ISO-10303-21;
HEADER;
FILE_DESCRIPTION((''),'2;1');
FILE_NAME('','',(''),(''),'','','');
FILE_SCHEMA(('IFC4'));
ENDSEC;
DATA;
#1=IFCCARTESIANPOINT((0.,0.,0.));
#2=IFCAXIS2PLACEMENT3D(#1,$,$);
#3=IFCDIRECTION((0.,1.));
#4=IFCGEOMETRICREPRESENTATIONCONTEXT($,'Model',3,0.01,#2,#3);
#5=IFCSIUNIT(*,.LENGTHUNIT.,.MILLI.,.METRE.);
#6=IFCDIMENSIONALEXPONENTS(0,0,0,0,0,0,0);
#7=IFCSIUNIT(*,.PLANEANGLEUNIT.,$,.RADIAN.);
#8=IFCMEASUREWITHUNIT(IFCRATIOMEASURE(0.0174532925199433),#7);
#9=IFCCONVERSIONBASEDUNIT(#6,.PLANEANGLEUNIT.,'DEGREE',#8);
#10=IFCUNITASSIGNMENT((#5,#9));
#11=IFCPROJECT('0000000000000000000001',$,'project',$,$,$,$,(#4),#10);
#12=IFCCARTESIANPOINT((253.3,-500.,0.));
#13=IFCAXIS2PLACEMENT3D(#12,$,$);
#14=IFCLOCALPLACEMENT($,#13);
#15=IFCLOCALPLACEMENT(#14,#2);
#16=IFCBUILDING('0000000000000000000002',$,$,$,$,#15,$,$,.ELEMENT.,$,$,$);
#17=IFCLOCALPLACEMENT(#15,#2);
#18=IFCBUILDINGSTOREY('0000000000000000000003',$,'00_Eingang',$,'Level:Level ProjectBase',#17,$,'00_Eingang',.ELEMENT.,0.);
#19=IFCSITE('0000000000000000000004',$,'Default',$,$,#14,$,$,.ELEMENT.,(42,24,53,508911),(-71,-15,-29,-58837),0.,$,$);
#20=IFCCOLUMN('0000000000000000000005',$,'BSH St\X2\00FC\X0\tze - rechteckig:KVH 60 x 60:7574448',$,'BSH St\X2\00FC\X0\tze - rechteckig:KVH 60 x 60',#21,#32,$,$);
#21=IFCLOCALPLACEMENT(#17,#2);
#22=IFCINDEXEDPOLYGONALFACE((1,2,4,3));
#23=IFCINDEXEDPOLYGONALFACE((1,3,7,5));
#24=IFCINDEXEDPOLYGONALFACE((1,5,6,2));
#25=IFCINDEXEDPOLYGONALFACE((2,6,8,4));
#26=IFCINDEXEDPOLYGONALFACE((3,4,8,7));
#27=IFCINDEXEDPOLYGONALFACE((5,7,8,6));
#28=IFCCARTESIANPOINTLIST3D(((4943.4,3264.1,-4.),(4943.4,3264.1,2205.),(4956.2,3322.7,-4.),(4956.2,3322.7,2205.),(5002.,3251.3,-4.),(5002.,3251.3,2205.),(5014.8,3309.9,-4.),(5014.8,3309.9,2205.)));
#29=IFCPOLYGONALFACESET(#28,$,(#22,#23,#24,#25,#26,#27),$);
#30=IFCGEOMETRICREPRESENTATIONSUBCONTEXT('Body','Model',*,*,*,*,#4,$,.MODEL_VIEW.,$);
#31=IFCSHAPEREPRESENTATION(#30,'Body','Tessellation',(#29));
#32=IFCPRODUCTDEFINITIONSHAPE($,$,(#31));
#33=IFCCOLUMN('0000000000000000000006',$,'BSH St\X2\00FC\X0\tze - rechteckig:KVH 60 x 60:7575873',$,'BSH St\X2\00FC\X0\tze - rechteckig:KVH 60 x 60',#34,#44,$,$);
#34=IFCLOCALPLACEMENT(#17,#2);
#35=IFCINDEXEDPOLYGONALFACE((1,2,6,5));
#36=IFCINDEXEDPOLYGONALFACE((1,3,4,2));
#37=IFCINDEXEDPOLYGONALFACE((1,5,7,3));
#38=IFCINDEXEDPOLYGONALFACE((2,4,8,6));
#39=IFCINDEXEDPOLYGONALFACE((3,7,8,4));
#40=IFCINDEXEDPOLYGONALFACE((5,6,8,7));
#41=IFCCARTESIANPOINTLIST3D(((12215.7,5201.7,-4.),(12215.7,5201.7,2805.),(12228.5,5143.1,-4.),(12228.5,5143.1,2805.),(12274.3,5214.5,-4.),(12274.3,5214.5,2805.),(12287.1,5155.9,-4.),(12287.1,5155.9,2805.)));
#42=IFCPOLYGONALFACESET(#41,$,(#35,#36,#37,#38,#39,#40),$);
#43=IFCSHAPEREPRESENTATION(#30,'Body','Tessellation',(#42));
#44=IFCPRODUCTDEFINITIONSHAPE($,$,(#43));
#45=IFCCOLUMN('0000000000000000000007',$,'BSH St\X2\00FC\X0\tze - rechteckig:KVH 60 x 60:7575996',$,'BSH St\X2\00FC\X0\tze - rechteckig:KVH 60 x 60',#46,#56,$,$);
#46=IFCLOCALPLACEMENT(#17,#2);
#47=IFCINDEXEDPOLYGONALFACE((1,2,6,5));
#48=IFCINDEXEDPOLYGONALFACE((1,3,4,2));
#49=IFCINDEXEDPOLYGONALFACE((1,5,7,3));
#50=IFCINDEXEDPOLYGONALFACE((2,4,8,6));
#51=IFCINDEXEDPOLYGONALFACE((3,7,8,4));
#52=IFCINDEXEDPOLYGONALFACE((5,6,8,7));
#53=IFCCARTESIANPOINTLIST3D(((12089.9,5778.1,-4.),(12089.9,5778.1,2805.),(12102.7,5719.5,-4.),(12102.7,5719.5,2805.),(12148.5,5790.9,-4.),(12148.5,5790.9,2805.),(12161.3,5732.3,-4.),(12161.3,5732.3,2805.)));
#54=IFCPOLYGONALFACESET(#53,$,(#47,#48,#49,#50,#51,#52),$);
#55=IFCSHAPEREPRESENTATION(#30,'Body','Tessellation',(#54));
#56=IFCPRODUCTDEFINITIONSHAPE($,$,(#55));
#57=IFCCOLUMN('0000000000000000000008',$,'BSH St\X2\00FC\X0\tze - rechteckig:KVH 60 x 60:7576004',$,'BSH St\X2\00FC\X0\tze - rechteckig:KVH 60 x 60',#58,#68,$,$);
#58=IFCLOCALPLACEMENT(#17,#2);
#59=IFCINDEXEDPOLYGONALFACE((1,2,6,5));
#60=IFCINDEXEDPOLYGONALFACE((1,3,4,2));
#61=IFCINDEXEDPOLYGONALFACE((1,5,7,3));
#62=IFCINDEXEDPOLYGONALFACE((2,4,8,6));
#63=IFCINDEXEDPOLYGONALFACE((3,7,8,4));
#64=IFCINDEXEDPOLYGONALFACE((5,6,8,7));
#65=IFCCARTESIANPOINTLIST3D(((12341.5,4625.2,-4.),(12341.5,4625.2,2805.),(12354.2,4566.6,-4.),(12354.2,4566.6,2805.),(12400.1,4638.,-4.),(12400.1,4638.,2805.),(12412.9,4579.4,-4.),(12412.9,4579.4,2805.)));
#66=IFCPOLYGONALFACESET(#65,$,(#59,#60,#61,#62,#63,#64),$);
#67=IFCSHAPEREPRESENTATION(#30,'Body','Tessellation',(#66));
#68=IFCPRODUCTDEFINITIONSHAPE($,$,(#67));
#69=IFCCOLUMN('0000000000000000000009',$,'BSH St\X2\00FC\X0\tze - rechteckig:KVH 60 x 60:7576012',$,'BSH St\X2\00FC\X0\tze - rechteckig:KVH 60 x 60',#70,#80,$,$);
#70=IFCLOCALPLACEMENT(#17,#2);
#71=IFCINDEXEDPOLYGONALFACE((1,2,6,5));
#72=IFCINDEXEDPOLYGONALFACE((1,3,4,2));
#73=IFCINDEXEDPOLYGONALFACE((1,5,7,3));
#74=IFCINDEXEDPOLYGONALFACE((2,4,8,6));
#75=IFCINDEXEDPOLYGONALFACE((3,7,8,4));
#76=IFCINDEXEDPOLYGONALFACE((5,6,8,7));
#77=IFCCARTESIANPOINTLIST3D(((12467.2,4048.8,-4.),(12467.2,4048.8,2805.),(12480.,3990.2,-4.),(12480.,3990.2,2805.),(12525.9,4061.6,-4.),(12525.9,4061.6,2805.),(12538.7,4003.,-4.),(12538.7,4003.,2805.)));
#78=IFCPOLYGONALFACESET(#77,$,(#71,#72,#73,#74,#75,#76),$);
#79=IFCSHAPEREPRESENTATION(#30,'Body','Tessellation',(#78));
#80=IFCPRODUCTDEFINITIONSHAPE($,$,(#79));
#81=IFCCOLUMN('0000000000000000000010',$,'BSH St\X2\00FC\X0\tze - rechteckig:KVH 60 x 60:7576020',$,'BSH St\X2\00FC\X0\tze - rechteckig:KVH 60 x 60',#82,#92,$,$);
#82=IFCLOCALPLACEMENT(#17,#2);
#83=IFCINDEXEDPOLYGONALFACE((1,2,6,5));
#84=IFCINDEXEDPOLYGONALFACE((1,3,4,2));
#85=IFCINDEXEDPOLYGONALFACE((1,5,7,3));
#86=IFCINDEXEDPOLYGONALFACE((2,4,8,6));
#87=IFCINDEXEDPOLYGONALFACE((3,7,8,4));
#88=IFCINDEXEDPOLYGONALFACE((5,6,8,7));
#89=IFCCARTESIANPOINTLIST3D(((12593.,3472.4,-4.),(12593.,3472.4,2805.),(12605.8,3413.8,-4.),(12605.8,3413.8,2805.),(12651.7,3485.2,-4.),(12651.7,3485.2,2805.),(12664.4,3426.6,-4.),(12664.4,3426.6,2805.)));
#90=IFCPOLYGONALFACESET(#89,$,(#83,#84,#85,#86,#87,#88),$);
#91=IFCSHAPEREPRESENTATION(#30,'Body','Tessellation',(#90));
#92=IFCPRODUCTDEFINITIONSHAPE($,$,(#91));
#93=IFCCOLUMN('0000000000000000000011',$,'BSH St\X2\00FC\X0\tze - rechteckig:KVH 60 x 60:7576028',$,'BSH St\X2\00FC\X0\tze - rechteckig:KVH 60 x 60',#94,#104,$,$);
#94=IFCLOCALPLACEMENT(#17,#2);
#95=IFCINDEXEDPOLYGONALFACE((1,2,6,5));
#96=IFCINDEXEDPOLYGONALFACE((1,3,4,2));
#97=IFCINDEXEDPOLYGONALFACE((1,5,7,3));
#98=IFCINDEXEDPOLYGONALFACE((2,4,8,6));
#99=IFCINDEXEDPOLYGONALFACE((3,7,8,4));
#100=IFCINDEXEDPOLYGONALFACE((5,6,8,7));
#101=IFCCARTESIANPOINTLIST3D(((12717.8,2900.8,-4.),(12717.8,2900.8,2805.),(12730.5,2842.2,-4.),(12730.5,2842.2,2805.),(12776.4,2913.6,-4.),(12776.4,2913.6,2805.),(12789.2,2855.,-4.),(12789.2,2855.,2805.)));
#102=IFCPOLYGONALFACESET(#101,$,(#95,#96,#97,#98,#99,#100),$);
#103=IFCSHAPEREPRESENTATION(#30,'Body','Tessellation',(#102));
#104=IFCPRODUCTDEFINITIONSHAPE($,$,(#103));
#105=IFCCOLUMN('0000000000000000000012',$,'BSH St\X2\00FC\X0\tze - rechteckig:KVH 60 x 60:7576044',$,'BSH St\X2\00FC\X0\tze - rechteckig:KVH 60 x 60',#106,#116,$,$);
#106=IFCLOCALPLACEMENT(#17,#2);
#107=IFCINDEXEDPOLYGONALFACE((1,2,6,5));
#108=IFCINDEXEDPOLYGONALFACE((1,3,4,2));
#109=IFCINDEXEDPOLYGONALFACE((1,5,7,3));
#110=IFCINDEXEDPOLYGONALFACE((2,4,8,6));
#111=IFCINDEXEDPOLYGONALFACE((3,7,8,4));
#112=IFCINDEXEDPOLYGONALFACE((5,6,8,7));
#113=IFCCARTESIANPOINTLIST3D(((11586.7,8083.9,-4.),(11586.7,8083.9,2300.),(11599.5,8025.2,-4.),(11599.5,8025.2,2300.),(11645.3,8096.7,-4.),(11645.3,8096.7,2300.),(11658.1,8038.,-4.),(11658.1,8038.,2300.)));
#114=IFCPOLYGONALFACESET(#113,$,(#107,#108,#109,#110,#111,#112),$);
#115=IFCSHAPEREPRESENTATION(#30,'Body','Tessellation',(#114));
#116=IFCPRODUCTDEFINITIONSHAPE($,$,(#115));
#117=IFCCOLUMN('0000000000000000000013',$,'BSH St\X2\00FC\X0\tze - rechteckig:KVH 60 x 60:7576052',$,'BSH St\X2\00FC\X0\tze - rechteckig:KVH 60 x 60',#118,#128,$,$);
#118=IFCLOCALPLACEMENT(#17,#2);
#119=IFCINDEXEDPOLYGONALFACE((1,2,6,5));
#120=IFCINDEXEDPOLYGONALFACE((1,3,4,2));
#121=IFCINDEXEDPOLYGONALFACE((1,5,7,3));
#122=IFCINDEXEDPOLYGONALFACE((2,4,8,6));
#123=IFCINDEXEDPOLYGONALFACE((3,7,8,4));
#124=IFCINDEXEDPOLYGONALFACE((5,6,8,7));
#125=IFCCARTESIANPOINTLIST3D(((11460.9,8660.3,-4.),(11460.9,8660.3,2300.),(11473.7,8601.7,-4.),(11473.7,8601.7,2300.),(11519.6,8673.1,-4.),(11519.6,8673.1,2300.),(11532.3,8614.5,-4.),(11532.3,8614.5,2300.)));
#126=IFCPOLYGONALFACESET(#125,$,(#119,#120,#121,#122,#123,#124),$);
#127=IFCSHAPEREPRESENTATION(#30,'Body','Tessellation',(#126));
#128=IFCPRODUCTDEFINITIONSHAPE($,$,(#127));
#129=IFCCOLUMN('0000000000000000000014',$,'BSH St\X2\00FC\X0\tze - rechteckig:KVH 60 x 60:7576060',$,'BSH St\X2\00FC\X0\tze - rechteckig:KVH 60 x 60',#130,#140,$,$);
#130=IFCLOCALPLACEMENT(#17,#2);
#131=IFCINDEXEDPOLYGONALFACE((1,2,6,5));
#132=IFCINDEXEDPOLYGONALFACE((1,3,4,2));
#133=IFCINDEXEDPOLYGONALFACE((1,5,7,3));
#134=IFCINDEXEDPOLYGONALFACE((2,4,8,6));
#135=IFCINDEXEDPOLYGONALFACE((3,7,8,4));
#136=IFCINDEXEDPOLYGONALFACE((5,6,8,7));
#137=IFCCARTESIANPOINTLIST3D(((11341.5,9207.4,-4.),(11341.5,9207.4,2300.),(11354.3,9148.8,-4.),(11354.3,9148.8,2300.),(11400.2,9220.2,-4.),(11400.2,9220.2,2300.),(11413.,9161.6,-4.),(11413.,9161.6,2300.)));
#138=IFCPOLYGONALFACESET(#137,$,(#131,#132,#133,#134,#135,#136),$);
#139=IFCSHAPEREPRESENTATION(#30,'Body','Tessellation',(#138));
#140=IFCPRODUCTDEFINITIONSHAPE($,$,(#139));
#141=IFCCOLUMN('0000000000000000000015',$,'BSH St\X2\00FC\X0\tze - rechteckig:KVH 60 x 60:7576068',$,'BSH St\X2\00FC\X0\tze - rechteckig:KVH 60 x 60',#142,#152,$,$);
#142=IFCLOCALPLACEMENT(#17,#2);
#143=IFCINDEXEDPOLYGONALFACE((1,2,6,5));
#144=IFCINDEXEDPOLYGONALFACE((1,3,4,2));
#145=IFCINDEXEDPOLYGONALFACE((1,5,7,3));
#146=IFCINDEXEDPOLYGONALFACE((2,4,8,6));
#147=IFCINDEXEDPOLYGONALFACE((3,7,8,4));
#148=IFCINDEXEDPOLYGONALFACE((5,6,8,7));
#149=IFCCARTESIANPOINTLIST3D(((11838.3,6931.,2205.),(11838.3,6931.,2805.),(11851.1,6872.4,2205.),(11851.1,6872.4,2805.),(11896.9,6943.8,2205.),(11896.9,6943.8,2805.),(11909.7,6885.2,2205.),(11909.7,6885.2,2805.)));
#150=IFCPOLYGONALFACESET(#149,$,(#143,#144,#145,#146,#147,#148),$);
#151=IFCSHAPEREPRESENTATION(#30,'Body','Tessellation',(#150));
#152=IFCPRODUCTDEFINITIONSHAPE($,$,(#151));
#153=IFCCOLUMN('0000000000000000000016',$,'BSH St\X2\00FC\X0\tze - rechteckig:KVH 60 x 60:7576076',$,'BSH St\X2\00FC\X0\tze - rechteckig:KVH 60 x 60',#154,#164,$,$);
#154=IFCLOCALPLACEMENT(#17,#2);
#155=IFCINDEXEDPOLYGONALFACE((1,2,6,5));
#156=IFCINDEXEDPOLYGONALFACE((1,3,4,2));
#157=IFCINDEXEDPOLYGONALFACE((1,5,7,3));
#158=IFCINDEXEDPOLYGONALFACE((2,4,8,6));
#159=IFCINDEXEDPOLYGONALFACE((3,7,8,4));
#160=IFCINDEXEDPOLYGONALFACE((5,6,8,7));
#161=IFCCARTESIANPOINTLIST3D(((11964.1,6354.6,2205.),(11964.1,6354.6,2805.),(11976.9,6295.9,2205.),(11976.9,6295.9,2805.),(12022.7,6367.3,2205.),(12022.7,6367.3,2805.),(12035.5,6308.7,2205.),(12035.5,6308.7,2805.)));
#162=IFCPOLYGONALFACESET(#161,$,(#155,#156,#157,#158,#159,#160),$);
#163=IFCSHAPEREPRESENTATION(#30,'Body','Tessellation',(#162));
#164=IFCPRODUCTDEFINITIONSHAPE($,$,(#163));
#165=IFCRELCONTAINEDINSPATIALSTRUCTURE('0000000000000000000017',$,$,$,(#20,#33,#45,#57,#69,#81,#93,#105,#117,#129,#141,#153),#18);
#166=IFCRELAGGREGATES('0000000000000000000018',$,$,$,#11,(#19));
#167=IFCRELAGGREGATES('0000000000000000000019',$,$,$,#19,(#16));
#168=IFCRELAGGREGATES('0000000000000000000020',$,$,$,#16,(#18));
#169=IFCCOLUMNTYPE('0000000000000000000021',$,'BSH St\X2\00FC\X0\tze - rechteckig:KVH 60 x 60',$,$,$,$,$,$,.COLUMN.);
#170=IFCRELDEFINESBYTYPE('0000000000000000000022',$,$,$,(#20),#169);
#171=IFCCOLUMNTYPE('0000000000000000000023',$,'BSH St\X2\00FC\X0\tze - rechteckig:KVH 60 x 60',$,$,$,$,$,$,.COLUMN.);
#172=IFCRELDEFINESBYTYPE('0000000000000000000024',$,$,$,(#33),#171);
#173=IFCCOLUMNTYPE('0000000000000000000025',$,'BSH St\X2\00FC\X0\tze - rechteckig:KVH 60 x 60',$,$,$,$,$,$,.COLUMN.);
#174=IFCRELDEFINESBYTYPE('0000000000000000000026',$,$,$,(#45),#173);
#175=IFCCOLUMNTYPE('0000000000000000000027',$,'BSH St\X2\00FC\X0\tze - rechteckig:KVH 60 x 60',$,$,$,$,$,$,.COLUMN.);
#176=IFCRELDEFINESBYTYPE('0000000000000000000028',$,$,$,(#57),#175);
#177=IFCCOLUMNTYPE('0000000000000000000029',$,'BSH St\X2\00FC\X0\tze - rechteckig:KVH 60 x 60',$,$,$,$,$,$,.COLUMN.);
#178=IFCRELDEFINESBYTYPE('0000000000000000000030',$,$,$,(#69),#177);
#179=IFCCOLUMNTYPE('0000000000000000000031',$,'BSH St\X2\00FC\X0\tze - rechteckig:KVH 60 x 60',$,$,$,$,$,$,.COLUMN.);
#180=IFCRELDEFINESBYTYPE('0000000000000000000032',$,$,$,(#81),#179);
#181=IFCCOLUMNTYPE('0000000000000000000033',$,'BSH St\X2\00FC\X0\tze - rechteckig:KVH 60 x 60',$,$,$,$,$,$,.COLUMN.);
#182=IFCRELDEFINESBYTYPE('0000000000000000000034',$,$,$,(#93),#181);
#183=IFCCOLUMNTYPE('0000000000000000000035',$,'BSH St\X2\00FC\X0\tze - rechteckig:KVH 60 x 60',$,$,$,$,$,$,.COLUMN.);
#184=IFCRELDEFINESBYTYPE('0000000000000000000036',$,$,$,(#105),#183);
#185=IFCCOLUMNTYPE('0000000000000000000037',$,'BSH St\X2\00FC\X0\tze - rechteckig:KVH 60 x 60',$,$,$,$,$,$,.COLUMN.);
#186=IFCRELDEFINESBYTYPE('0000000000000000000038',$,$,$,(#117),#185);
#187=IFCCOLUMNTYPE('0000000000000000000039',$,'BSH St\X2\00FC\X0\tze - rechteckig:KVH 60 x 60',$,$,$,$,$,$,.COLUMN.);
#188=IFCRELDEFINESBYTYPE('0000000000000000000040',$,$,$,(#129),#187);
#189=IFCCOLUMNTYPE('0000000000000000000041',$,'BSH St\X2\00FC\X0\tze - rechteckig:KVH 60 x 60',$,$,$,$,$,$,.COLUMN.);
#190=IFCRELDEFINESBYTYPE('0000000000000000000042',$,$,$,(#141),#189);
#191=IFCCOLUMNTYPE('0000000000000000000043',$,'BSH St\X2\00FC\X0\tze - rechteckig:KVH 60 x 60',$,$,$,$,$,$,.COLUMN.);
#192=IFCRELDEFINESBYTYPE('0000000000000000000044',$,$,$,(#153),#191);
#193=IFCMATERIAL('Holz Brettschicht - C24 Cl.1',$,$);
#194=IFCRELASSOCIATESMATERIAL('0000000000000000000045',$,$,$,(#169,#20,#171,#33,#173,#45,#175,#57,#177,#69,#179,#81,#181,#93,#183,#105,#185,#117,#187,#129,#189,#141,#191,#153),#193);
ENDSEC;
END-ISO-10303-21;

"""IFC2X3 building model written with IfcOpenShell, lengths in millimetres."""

from ifc_helpers import new_model, entity, si_unit, converted_unit, direction, frame, frame_2d, origin, origin_2d_with_axis, place, context, subcontext, project, spatial, rectangle, extrude, source, transform, mapped, material, type_object, type_shapes, element, save


model = new_model("IFC2X3")

# Units and contexts
model_context = context("Model", 3, precision=0.01, world=origin(), true_north=direction((0.0, 1.0)))
body_context = subcontext(model_context, "Body", "Model", "MODEL_VIEW")
ifc_project = project(units=[si_unit("LENGTHUNIT", "METRE", prefix="MILLI"), converted_unit("PLANEANGLEUNIT", "DEGREE", entity("IfcRatioMeasure", 0.0174532925199433), si_unit("PLANEANGLEUNIT", "RADIAN"), dimensions=[0, 0, 0, 0, 0, 0, 0])], contexts=[model_context])

# Site, building, storey
site_placement = place(None, frame((253.3, -500.0, 0.0)))
site = spatial("IfcSite", under=ifc_project, at=site_placement, Name="Default", CompositionType="ELEMENT", RefLatitude=(42, 24, 53, 508911), RefLongitude=(-71, -15, -29, -58837), RefElevation=0.0)
building_placement = place(site_placement, origin())
building = spatial("IfcBuilding", under=site, at=building_placement, CompositionType="ELEMENT")
storey_placement = place(building_placement, origin())
storey = spatial("IfcBuildingStorey", under=building, at=storey_placement, Name="00_Eingang", ObjectType="Level:Level ProjectBase", LongName="00_Eingang", CompositionType="ELEMENT", Elevation=0.0)

# Columns
ifc_material_1 = material(Name="Holz Brettschicht - C24 Cl.1")
column_type_1 = type_object("IfcColumnType", Name="BSH Stütze - rechteckig:KVH 60 x 60", PredefinedType="COLUMN", material=ifc_material_1)
shared_shape_1 = source(origin(), body_context, "Body", "SweptSolid", [
    extrude(rectangle(XDim=60.0, YDim=60.0, at=frame_2d((0.0, 0.0), x_axis=(1.0, 0.0))), frame((4979.1, 3287.0, -4.0), z_axis=(0.0, 0.0, 1.0), x_axis=(0.213201, 0.977008, 0.0)), (0.0, 0.0, 1.0), 2209.0),
])
type_shapes(column_type_1, [shared_shape_1])
column_1_placement = place(storey_placement, origin())
element("IfcColumn", 1, at=column_1_placement, inside=storey, type_object=column_type_1, material=ifc_material_1, Name="BSH Stütze - rechteckig:KVH 60 x 60:7574448", ObjectType="BSH Stütze - rechteckig:KVH 60 x 60", context=body_context, shape_type="MappedRepresentation", body=[
    mapped(shared_shape_1, transform((0.0, 0.0, 0.0), scale=1.0)),
])
column_type_2 = type_object("IfcColumnType", Name="BSH Stütze - rechteckig:KVH 60 x 60", PredefinedType="COLUMN", material=ifc_material_1)
shared_shape_2 = source(origin(), body_context, "Body", "SweptSolid", [
    extrude(rectangle(XDim=60.0, YDim=60.0, at=origin_2d_with_axis()), frame((12251.4, 5178.8, -4.0), z_axis=(0.0, 0.0, 1.0), x_axis=(-0.213201, 0.977008, 0.0)), (0.0, 0.0, 1.0), 2809.0),
])
type_shapes(column_type_2, [shared_shape_2])
column_2_placement = place(storey_placement, origin())
element("IfcColumn", 2, at=column_2_placement, inside=storey, type_object=column_type_2, material=ifc_material_1, Name="BSH Stütze - rechteckig:KVH 60 x 60:7575873", ObjectType="BSH Stütze - rechteckig:KVH 60 x 60", context=body_context, shape_type="MappedRepresentation", body=[
    mapped(shared_shape_2, transform((0.0, 0.0, 0.0), scale=1.0)),
])
column_type_3 = type_object("IfcColumnType", Name="BSH Stütze - rechteckig:KVH 60 x 60", PredefinedType="COLUMN", material=ifc_material_1)
shared_shape_3 = source(origin(), body_context, "Body", "SweptSolid", [
    extrude(rectangle(XDim=60.0, YDim=60.0, at=origin_2d_with_axis()), frame((12125.6, 5755.2, -4.0), z_axis=(0.0, 0.0, 1.0), x_axis=(-0.213201, 0.977008, 0.0)), (0.0, 0.0, 1.0), 2809.0),
])
type_shapes(column_type_3, [shared_shape_3])
column_3_placement = place(storey_placement, origin())
element("IfcColumn", 3, at=column_3_placement, inside=storey, type_object=column_type_3, material=ifc_material_1, Name="BSH Stütze - rechteckig:KVH 60 x 60:7575996", ObjectType="BSH Stütze - rechteckig:KVH 60 x 60", context=body_context, shape_type="MappedRepresentation", body=[
    mapped(shared_shape_3, transform((0.0, 0.0, 0.0), scale=1.0)),
])
column_type_4 = type_object("IfcColumnType", Name="BSH Stütze - rechteckig:KVH 60 x 60", PredefinedType="COLUMN", material=ifc_material_1)
shared_shape_4 = source(origin(), body_context, "Body", "SweptSolid", [
    extrude(rectangle(XDim=60.0, YDim=60.0, at=origin_2d_with_axis()), frame((12377.2, 4602.3, -4.0), z_axis=(0.0, 0.0, 1.0), x_axis=(-0.213201, 0.977008, 0.0)), (0.0, 0.0, 1.0), 2809.0),
])
type_shapes(column_type_4, [shared_shape_4])
column_4_placement = place(storey_placement, origin())
element("IfcColumn", 4, at=column_4_placement, inside=storey, type_object=column_type_4, material=ifc_material_1, Name="BSH Stütze - rechteckig:KVH 60 x 60:7576004", ObjectType="BSH Stütze - rechteckig:KVH 60 x 60", context=body_context, shape_type="MappedRepresentation", body=[
    mapped(shared_shape_4, transform((0.0, 0.0, 0.0), scale=1.0)),
])
column_type_5 = type_object("IfcColumnType", Name="BSH Stütze - rechteckig:KVH 60 x 60", PredefinedType="COLUMN", material=ifc_material_1)
shared_shape_5 = source(origin(), body_context, "Body", "SweptSolid", [
    extrude(rectangle(XDim=60.0, YDim=60.0, at=origin_2d_with_axis()), frame((12503.0, 4025.9, -4.0), z_axis=(0.0, 0.0, 1.0), x_axis=(-0.213201, 0.977008, 0.0)), (0.0, 0.0, 1.0), 2809.0),
])
type_shapes(column_type_5, [shared_shape_5])
column_5_placement = place(storey_placement, origin())
element("IfcColumn", 5, at=column_5_placement, inside=storey, type_object=column_type_5, material=ifc_material_1, Name="BSH Stütze - rechteckig:KVH 60 x 60:7576012", ObjectType="BSH Stütze - rechteckig:KVH 60 x 60", context=body_context, shape_type="MappedRepresentation", body=[
    mapped(shared_shape_5, transform((0.0, 0.0, 0.0), scale=1.0)),
])
column_type_6 = type_object("IfcColumnType", Name="BSH Stütze - rechteckig:KVH 60 x 60", PredefinedType="COLUMN", material=ifc_material_1)
shared_shape_6 = source(origin(), body_context, "Body", "SweptSolid", [
    extrude(rectangle(XDim=60.0, YDim=60.0, at=origin_2d_with_axis()), frame((12628.7, 3449.5, -4.0), z_axis=(0.0, 0.0, 1.0), x_axis=(-0.213201, 0.977008, 0.0)), (0.0, 0.0, 1.0), 2809.0),
])
type_shapes(column_type_6, [shared_shape_6])
column_6_placement = place(storey_placement, origin())
element("IfcColumn", 6, at=column_6_placement, inside=storey, type_object=column_type_6, material=ifc_material_1, Name="BSH Stütze - rechteckig:KVH 60 x 60:7576020", ObjectType="BSH Stütze - rechteckig:KVH 60 x 60", context=body_context, shape_type="MappedRepresentation", body=[
    mapped(shared_shape_6, transform((0.0, 0.0, 0.0), scale=1.0)),
])
column_type_7 = type_object("IfcColumnType", Name="BSH Stütze - rechteckig:KVH 60 x 60", PredefinedType="COLUMN", material=ifc_material_1)
shared_shape_7 = source(origin(), body_context, "Body", "SweptSolid", [
    extrude(rectangle(XDim=60.0, YDim=60.0, at=origin_2d_with_axis()), frame((12753.5, 2877.9, -4.0), z_axis=(0.0, 0.0, 1.0), x_axis=(-0.213201, 0.977008, 0.0)), (0.0, 0.0, 1.0), 2809.0),
])
type_shapes(column_type_7, [shared_shape_7])
column_7_placement = place(storey_placement, origin())
element("IfcColumn", 7, at=column_7_placement, inside=storey, type_object=column_type_7, material=ifc_material_1, Name="BSH Stütze - rechteckig:KVH 60 x 60:7576028", ObjectType="BSH Stütze - rechteckig:KVH 60 x 60", context=body_context, shape_type="MappedRepresentation", body=[
    mapped(shared_shape_7, transform((0.0, 0.0, 0.0), scale=1.0)),
])
column_type_8 = type_object("IfcColumnType", Name="BSH Stütze - rechteckig:KVH 60 x 60", PredefinedType="COLUMN", material=ifc_material_1)
shared_shape_8 = source(origin(), body_context, "Body", "SweptSolid", [
    extrude(rectangle(XDim=60.0, YDim=60.0, at=frame_2d((0.0, 0.0), x_axis=(1.0, 0.0))), frame((11622.4, 8060.9, -4.0), z_axis=(0.0, 0.0, 1.0), x_axis=(-0.213201, 0.977008, 0.0)), (0.0, 0.0, 1.0), 2304.0),
])
type_shapes(column_type_8, [shared_shape_8])
column_8_placement = place(storey_placement, origin())
element("IfcColumn", 8, at=column_8_placement, inside=storey, type_object=column_type_8, material=ifc_material_1, Name="BSH Stütze - rechteckig:KVH 60 x 60:7576044", ObjectType="BSH Stütze - rechteckig:KVH 60 x 60", context=body_context, shape_type="MappedRepresentation", body=[
    mapped(shared_shape_8, transform((0.0, 0.0, 0.0), scale=1.0)),
])
column_type_9 = type_object("IfcColumnType", Name="BSH Stütze - rechteckig:KVH 60 x 60", PredefinedType="COLUMN", material=ifc_material_1)
shared_shape_9 = source(origin(), body_context, "Body", "SweptSolid", [
    extrude(rectangle(XDim=60.0, YDim=60.0, at=origin_2d_with_axis()), frame((11496.6, 8637.4, -4.0), z_axis=(0.0, 0.0, 1.0), x_axis=(-0.213201, 0.977008, 0.0)), (0.0, 0.0, 1.0), 2304.0),
])
type_shapes(column_type_9, [shared_shape_9])
column_9_placement = place(storey_placement, origin())
element("IfcColumn", 9, at=column_9_placement, inside=storey, type_object=column_type_9, material=ifc_material_1, Name="BSH Stütze - rechteckig:KVH 60 x 60:7576052", ObjectType="BSH Stütze - rechteckig:KVH 60 x 60", context=body_context, shape_type="MappedRepresentation", body=[
    mapped(shared_shape_9, transform((0.0, 0.0, 0.0), scale=1.0)),
])
column_type_10 = type_object("IfcColumnType", Name="BSH Stütze - rechteckig:KVH 60 x 60", PredefinedType="COLUMN", material=ifc_material_1)
shared_shape_10 = source(origin(), body_context, "Body", "SweptSolid", [
    extrude(rectangle(XDim=60.0, YDim=60.0, at=frame_2d((0.0, 0.0), x_axis=(1.0, 0.0))), frame((11377.3, 9184.5, -4.0), z_axis=(0.0, 0.0, 1.0), x_axis=(-0.213201, 0.977008, 0.0)), (0.0, 0.0, 1.0), 2304.0),
])
type_shapes(column_type_10, [shared_shape_10])
column_10_placement = place(storey_placement, origin())
element("IfcColumn", 10, at=column_10_placement, inside=storey, type_object=column_type_10, material=ifc_material_1, Name="BSH Stütze - rechteckig:KVH 60 x 60:7576060", ObjectType="BSH Stütze - rechteckig:KVH 60 x 60", context=body_context, shape_type="MappedRepresentation", body=[
    mapped(shared_shape_10, transform((0.0, 0.0, 0.0), scale=1.0)),
])
column_type_11 = type_object("IfcColumnType", Name="BSH Stütze - rechteckig:KVH 60 x 60", PredefinedType="COLUMN", material=ifc_material_1)
shared_shape_11 = source(origin(), body_context, "Body", "SweptSolid", [
    extrude(rectangle(XDim=60.0, YDim=60.0, at=frame_2d((0.0, 0.0), x_axis=(1.0, 0.0))), frame((11874.0, 6908.1, 2205.0), z_axis=(0.0, 0.0, 1.0), x_axis=(-0.213201, 0.977008, 0.0)), (0.0, 0.0, 1.0), 600.0),
])
type_shapes(column_type_11, [shared_shape_11])
column_11_placement = place(storey_placement, origin())
element("IfcColumn", 11, at=column_11_placement, inside=storey, type_object=column_type_11, material=ifc_material_1, Name="BSH Stütze - rechteckig:KVH 60 x 60:7576068", ObjectType="BSH Stütze - rechteckig:KVH 60 x 60", context=body_context, shape_type="MappedRepresentation", body=[
    mapped(shared_shape_11, transform((0.0, 0.0, 0.0), scale=1.0)),
])
column_type_12 = type_object("IfcColumnType", Name="BSH Stütze - rechteckig:KVH 60 x 60", PredefinedType="COLUMN", material=ifc_material_1)
shared_shape_12 = source(origin(), body_context, "Body", "SweptSolid", [
    extrude(rectangle(XDim=60.0, YDim=60.0, at=origin_2d_with_axis()), frame((11999.8, 6331.6, 2205.0), z_axis=(0.0, 0.0, 1.0), x_axis=(-0.213201, 0.977008, 0.0)), (0.0, 0.0, 1.0), 600.0),
])
type_shapes(column_type_12, [shared_shape_12])
column_12_placement = place(storey_placement, origin())
element("IfcColumn", 12, at=column_12_placement, inside=storey, type_object=column_type_12, material=ifc_material_1, Name="BSH Stütze - rechteckig:KVH 60 x 60:7576076", ObjectType="BSH Stütze - rechteckig:KVH 60 x 60", context=body_context, shape_type="MappedRepresentation", body=[
    mapped(shared_shape_12, transform((0.0, 0.0, 0.0), scale=1.0)),
])

save(model, "model.ifc")
